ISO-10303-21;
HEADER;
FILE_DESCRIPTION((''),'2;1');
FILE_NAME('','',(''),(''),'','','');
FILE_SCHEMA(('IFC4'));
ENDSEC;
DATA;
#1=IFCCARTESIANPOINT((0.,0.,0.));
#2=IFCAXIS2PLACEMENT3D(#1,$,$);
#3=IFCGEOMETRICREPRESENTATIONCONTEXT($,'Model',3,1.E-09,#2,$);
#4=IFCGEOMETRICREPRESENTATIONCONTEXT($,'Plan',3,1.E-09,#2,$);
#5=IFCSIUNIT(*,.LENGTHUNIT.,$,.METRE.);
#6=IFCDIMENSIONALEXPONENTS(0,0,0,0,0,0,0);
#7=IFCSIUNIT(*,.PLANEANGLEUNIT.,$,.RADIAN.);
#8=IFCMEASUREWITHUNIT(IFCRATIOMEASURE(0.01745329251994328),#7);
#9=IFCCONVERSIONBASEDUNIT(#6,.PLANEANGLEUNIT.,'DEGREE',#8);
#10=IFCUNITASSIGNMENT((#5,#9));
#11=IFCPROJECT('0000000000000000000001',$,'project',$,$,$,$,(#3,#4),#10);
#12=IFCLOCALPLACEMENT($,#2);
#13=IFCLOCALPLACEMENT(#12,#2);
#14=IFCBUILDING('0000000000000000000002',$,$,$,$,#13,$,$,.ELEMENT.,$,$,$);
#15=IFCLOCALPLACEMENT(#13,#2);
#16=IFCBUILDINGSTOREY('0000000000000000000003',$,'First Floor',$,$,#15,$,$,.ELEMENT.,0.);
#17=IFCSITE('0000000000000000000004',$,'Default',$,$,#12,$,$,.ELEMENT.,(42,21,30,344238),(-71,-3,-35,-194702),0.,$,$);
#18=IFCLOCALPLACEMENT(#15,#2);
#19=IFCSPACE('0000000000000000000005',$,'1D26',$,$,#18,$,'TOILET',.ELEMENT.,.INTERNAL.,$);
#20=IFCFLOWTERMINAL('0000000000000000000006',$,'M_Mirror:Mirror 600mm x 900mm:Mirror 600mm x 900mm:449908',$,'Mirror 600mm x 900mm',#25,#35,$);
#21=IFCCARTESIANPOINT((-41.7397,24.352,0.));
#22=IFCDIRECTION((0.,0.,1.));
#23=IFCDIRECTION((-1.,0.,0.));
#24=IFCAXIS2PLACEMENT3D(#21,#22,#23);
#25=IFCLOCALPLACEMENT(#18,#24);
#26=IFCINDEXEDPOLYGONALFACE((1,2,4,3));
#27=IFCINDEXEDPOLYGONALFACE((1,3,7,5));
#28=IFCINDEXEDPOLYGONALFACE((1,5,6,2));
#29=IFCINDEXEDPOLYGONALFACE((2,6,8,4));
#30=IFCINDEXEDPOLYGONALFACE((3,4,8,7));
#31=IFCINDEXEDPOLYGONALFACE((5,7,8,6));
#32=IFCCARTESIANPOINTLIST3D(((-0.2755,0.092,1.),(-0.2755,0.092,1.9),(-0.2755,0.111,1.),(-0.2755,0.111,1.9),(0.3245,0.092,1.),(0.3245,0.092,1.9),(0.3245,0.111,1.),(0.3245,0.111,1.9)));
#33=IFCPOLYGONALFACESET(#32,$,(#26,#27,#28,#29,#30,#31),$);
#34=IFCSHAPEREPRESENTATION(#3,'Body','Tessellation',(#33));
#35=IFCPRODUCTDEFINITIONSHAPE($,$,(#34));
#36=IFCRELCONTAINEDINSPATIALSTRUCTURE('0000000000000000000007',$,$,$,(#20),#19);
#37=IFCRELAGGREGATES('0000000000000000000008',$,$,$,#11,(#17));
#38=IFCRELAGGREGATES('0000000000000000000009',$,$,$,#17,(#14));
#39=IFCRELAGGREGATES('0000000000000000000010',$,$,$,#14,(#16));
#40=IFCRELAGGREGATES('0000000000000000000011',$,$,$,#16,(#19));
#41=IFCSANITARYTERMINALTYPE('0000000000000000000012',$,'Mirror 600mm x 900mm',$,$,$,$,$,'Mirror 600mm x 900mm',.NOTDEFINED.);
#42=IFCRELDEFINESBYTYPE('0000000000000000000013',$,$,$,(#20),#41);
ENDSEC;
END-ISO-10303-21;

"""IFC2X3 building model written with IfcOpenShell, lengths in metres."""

from ifc_helpers import new_model, entity, si_unit, converted_unit, frame, origin, origin_2d_with_axis, place, context, project, spatial, rectangle, extrude, source, transform, mapped, type_object, type_shapes, element, save


model = new_model("IFC2X3")

# Units and contexts
model_context = context("Model", 3, precision=1e-09, world=origin())
plan_context = context("Plan", 3, precision=1e-09, world=origin())
ifc_project = project(units=[si_unit("LENGTHUNIT", "METRE"), converted_unit("PLANEANGLEUNIT", "DEGREE", entity("IfcRatioMeasure", 0.01745329251994328), si_unit("PLANEANGLEUNIT", "RADIAN"), dimensions=[0, 0, 0, 0, 0, 0, 0])], contexts=[model_context, plan_context])

# Site, building, storey
site_placement = place(None, origin())
site = spatial("IfcSite", under=ifc_project, at=site_placement, Name="Default", CompositionType="ELEMENT", RefLatitude=(42, 21, 30, 344238), RefLongitude=(-71, -3, -35, -194702), RefElevation=0.0)
building_placement = place(site_placement, origin())
building = spatial("IfcBuilding", under=site, at=building_placement, CompositionType="ELEMENT")
storey_placement = place(building_placement, origin())
storey = spatial("IfcBuildingStorey", under=building, at=storey_placement, Name="First Floor", CompositionType="ELEMENT", Elevation=0.0)

# Shared definitions
space_placement = place(storey_placement, origin())
space = spatial("IfcSpace", under=storey, at=space_placement, Name="1D26", LongName="TOILET", CompositionType="ELEMENT", InteriorOrExteriorSpace="INTERNAL")

# Flow terminal
sanitary_terminal_type = type_object("IfcSanitaryTerminalType", Name="Mirror 600mm x 900mm", ElementType="Mirror 600mm x 900mm", PredefinedType="NOTDEFINED")
shared_shape_1 = source(origin(), model_context, "Body", "SweptSolid", [
    extrude(rectangle(XDim=0.0191, YDim=0.6, at=origin_2d_with_axis()), frame((0.0245, 0.1015, 1.0), z_axis=(0.0, 0.0, 1.0), x_axis=(0.0, -1.0, 0.0)), (0.0, 0.0, 1.0), 0.9),
])
type_shapes(sanitary_terminal_type, [shared_shape_1])
flow_terminal_placement = place(space_placement, frame((-41.7397, 24.352, 0.0), z_axis=(0.0, 0.0, 1.0), x_axis=(-1.0, 0.0, 0.0)))
element("IfcFlowTerminal", 1, at=flow_terminal_placement, inside=space, type_object=sanitary_terminal_type, Name="M_Mirror:Mirror 600mm x 900mm:Mirror 600mm x 900mm:449908", ObjectType="Mirror 600mm x 900mm", context=model_context, shape_type="MappedRepresentation", body=[
    mapped(shared_shape_1, transform((0.0, 0.0, 0.0), scale=1.0)),
])

save(model, "model.ifc")
